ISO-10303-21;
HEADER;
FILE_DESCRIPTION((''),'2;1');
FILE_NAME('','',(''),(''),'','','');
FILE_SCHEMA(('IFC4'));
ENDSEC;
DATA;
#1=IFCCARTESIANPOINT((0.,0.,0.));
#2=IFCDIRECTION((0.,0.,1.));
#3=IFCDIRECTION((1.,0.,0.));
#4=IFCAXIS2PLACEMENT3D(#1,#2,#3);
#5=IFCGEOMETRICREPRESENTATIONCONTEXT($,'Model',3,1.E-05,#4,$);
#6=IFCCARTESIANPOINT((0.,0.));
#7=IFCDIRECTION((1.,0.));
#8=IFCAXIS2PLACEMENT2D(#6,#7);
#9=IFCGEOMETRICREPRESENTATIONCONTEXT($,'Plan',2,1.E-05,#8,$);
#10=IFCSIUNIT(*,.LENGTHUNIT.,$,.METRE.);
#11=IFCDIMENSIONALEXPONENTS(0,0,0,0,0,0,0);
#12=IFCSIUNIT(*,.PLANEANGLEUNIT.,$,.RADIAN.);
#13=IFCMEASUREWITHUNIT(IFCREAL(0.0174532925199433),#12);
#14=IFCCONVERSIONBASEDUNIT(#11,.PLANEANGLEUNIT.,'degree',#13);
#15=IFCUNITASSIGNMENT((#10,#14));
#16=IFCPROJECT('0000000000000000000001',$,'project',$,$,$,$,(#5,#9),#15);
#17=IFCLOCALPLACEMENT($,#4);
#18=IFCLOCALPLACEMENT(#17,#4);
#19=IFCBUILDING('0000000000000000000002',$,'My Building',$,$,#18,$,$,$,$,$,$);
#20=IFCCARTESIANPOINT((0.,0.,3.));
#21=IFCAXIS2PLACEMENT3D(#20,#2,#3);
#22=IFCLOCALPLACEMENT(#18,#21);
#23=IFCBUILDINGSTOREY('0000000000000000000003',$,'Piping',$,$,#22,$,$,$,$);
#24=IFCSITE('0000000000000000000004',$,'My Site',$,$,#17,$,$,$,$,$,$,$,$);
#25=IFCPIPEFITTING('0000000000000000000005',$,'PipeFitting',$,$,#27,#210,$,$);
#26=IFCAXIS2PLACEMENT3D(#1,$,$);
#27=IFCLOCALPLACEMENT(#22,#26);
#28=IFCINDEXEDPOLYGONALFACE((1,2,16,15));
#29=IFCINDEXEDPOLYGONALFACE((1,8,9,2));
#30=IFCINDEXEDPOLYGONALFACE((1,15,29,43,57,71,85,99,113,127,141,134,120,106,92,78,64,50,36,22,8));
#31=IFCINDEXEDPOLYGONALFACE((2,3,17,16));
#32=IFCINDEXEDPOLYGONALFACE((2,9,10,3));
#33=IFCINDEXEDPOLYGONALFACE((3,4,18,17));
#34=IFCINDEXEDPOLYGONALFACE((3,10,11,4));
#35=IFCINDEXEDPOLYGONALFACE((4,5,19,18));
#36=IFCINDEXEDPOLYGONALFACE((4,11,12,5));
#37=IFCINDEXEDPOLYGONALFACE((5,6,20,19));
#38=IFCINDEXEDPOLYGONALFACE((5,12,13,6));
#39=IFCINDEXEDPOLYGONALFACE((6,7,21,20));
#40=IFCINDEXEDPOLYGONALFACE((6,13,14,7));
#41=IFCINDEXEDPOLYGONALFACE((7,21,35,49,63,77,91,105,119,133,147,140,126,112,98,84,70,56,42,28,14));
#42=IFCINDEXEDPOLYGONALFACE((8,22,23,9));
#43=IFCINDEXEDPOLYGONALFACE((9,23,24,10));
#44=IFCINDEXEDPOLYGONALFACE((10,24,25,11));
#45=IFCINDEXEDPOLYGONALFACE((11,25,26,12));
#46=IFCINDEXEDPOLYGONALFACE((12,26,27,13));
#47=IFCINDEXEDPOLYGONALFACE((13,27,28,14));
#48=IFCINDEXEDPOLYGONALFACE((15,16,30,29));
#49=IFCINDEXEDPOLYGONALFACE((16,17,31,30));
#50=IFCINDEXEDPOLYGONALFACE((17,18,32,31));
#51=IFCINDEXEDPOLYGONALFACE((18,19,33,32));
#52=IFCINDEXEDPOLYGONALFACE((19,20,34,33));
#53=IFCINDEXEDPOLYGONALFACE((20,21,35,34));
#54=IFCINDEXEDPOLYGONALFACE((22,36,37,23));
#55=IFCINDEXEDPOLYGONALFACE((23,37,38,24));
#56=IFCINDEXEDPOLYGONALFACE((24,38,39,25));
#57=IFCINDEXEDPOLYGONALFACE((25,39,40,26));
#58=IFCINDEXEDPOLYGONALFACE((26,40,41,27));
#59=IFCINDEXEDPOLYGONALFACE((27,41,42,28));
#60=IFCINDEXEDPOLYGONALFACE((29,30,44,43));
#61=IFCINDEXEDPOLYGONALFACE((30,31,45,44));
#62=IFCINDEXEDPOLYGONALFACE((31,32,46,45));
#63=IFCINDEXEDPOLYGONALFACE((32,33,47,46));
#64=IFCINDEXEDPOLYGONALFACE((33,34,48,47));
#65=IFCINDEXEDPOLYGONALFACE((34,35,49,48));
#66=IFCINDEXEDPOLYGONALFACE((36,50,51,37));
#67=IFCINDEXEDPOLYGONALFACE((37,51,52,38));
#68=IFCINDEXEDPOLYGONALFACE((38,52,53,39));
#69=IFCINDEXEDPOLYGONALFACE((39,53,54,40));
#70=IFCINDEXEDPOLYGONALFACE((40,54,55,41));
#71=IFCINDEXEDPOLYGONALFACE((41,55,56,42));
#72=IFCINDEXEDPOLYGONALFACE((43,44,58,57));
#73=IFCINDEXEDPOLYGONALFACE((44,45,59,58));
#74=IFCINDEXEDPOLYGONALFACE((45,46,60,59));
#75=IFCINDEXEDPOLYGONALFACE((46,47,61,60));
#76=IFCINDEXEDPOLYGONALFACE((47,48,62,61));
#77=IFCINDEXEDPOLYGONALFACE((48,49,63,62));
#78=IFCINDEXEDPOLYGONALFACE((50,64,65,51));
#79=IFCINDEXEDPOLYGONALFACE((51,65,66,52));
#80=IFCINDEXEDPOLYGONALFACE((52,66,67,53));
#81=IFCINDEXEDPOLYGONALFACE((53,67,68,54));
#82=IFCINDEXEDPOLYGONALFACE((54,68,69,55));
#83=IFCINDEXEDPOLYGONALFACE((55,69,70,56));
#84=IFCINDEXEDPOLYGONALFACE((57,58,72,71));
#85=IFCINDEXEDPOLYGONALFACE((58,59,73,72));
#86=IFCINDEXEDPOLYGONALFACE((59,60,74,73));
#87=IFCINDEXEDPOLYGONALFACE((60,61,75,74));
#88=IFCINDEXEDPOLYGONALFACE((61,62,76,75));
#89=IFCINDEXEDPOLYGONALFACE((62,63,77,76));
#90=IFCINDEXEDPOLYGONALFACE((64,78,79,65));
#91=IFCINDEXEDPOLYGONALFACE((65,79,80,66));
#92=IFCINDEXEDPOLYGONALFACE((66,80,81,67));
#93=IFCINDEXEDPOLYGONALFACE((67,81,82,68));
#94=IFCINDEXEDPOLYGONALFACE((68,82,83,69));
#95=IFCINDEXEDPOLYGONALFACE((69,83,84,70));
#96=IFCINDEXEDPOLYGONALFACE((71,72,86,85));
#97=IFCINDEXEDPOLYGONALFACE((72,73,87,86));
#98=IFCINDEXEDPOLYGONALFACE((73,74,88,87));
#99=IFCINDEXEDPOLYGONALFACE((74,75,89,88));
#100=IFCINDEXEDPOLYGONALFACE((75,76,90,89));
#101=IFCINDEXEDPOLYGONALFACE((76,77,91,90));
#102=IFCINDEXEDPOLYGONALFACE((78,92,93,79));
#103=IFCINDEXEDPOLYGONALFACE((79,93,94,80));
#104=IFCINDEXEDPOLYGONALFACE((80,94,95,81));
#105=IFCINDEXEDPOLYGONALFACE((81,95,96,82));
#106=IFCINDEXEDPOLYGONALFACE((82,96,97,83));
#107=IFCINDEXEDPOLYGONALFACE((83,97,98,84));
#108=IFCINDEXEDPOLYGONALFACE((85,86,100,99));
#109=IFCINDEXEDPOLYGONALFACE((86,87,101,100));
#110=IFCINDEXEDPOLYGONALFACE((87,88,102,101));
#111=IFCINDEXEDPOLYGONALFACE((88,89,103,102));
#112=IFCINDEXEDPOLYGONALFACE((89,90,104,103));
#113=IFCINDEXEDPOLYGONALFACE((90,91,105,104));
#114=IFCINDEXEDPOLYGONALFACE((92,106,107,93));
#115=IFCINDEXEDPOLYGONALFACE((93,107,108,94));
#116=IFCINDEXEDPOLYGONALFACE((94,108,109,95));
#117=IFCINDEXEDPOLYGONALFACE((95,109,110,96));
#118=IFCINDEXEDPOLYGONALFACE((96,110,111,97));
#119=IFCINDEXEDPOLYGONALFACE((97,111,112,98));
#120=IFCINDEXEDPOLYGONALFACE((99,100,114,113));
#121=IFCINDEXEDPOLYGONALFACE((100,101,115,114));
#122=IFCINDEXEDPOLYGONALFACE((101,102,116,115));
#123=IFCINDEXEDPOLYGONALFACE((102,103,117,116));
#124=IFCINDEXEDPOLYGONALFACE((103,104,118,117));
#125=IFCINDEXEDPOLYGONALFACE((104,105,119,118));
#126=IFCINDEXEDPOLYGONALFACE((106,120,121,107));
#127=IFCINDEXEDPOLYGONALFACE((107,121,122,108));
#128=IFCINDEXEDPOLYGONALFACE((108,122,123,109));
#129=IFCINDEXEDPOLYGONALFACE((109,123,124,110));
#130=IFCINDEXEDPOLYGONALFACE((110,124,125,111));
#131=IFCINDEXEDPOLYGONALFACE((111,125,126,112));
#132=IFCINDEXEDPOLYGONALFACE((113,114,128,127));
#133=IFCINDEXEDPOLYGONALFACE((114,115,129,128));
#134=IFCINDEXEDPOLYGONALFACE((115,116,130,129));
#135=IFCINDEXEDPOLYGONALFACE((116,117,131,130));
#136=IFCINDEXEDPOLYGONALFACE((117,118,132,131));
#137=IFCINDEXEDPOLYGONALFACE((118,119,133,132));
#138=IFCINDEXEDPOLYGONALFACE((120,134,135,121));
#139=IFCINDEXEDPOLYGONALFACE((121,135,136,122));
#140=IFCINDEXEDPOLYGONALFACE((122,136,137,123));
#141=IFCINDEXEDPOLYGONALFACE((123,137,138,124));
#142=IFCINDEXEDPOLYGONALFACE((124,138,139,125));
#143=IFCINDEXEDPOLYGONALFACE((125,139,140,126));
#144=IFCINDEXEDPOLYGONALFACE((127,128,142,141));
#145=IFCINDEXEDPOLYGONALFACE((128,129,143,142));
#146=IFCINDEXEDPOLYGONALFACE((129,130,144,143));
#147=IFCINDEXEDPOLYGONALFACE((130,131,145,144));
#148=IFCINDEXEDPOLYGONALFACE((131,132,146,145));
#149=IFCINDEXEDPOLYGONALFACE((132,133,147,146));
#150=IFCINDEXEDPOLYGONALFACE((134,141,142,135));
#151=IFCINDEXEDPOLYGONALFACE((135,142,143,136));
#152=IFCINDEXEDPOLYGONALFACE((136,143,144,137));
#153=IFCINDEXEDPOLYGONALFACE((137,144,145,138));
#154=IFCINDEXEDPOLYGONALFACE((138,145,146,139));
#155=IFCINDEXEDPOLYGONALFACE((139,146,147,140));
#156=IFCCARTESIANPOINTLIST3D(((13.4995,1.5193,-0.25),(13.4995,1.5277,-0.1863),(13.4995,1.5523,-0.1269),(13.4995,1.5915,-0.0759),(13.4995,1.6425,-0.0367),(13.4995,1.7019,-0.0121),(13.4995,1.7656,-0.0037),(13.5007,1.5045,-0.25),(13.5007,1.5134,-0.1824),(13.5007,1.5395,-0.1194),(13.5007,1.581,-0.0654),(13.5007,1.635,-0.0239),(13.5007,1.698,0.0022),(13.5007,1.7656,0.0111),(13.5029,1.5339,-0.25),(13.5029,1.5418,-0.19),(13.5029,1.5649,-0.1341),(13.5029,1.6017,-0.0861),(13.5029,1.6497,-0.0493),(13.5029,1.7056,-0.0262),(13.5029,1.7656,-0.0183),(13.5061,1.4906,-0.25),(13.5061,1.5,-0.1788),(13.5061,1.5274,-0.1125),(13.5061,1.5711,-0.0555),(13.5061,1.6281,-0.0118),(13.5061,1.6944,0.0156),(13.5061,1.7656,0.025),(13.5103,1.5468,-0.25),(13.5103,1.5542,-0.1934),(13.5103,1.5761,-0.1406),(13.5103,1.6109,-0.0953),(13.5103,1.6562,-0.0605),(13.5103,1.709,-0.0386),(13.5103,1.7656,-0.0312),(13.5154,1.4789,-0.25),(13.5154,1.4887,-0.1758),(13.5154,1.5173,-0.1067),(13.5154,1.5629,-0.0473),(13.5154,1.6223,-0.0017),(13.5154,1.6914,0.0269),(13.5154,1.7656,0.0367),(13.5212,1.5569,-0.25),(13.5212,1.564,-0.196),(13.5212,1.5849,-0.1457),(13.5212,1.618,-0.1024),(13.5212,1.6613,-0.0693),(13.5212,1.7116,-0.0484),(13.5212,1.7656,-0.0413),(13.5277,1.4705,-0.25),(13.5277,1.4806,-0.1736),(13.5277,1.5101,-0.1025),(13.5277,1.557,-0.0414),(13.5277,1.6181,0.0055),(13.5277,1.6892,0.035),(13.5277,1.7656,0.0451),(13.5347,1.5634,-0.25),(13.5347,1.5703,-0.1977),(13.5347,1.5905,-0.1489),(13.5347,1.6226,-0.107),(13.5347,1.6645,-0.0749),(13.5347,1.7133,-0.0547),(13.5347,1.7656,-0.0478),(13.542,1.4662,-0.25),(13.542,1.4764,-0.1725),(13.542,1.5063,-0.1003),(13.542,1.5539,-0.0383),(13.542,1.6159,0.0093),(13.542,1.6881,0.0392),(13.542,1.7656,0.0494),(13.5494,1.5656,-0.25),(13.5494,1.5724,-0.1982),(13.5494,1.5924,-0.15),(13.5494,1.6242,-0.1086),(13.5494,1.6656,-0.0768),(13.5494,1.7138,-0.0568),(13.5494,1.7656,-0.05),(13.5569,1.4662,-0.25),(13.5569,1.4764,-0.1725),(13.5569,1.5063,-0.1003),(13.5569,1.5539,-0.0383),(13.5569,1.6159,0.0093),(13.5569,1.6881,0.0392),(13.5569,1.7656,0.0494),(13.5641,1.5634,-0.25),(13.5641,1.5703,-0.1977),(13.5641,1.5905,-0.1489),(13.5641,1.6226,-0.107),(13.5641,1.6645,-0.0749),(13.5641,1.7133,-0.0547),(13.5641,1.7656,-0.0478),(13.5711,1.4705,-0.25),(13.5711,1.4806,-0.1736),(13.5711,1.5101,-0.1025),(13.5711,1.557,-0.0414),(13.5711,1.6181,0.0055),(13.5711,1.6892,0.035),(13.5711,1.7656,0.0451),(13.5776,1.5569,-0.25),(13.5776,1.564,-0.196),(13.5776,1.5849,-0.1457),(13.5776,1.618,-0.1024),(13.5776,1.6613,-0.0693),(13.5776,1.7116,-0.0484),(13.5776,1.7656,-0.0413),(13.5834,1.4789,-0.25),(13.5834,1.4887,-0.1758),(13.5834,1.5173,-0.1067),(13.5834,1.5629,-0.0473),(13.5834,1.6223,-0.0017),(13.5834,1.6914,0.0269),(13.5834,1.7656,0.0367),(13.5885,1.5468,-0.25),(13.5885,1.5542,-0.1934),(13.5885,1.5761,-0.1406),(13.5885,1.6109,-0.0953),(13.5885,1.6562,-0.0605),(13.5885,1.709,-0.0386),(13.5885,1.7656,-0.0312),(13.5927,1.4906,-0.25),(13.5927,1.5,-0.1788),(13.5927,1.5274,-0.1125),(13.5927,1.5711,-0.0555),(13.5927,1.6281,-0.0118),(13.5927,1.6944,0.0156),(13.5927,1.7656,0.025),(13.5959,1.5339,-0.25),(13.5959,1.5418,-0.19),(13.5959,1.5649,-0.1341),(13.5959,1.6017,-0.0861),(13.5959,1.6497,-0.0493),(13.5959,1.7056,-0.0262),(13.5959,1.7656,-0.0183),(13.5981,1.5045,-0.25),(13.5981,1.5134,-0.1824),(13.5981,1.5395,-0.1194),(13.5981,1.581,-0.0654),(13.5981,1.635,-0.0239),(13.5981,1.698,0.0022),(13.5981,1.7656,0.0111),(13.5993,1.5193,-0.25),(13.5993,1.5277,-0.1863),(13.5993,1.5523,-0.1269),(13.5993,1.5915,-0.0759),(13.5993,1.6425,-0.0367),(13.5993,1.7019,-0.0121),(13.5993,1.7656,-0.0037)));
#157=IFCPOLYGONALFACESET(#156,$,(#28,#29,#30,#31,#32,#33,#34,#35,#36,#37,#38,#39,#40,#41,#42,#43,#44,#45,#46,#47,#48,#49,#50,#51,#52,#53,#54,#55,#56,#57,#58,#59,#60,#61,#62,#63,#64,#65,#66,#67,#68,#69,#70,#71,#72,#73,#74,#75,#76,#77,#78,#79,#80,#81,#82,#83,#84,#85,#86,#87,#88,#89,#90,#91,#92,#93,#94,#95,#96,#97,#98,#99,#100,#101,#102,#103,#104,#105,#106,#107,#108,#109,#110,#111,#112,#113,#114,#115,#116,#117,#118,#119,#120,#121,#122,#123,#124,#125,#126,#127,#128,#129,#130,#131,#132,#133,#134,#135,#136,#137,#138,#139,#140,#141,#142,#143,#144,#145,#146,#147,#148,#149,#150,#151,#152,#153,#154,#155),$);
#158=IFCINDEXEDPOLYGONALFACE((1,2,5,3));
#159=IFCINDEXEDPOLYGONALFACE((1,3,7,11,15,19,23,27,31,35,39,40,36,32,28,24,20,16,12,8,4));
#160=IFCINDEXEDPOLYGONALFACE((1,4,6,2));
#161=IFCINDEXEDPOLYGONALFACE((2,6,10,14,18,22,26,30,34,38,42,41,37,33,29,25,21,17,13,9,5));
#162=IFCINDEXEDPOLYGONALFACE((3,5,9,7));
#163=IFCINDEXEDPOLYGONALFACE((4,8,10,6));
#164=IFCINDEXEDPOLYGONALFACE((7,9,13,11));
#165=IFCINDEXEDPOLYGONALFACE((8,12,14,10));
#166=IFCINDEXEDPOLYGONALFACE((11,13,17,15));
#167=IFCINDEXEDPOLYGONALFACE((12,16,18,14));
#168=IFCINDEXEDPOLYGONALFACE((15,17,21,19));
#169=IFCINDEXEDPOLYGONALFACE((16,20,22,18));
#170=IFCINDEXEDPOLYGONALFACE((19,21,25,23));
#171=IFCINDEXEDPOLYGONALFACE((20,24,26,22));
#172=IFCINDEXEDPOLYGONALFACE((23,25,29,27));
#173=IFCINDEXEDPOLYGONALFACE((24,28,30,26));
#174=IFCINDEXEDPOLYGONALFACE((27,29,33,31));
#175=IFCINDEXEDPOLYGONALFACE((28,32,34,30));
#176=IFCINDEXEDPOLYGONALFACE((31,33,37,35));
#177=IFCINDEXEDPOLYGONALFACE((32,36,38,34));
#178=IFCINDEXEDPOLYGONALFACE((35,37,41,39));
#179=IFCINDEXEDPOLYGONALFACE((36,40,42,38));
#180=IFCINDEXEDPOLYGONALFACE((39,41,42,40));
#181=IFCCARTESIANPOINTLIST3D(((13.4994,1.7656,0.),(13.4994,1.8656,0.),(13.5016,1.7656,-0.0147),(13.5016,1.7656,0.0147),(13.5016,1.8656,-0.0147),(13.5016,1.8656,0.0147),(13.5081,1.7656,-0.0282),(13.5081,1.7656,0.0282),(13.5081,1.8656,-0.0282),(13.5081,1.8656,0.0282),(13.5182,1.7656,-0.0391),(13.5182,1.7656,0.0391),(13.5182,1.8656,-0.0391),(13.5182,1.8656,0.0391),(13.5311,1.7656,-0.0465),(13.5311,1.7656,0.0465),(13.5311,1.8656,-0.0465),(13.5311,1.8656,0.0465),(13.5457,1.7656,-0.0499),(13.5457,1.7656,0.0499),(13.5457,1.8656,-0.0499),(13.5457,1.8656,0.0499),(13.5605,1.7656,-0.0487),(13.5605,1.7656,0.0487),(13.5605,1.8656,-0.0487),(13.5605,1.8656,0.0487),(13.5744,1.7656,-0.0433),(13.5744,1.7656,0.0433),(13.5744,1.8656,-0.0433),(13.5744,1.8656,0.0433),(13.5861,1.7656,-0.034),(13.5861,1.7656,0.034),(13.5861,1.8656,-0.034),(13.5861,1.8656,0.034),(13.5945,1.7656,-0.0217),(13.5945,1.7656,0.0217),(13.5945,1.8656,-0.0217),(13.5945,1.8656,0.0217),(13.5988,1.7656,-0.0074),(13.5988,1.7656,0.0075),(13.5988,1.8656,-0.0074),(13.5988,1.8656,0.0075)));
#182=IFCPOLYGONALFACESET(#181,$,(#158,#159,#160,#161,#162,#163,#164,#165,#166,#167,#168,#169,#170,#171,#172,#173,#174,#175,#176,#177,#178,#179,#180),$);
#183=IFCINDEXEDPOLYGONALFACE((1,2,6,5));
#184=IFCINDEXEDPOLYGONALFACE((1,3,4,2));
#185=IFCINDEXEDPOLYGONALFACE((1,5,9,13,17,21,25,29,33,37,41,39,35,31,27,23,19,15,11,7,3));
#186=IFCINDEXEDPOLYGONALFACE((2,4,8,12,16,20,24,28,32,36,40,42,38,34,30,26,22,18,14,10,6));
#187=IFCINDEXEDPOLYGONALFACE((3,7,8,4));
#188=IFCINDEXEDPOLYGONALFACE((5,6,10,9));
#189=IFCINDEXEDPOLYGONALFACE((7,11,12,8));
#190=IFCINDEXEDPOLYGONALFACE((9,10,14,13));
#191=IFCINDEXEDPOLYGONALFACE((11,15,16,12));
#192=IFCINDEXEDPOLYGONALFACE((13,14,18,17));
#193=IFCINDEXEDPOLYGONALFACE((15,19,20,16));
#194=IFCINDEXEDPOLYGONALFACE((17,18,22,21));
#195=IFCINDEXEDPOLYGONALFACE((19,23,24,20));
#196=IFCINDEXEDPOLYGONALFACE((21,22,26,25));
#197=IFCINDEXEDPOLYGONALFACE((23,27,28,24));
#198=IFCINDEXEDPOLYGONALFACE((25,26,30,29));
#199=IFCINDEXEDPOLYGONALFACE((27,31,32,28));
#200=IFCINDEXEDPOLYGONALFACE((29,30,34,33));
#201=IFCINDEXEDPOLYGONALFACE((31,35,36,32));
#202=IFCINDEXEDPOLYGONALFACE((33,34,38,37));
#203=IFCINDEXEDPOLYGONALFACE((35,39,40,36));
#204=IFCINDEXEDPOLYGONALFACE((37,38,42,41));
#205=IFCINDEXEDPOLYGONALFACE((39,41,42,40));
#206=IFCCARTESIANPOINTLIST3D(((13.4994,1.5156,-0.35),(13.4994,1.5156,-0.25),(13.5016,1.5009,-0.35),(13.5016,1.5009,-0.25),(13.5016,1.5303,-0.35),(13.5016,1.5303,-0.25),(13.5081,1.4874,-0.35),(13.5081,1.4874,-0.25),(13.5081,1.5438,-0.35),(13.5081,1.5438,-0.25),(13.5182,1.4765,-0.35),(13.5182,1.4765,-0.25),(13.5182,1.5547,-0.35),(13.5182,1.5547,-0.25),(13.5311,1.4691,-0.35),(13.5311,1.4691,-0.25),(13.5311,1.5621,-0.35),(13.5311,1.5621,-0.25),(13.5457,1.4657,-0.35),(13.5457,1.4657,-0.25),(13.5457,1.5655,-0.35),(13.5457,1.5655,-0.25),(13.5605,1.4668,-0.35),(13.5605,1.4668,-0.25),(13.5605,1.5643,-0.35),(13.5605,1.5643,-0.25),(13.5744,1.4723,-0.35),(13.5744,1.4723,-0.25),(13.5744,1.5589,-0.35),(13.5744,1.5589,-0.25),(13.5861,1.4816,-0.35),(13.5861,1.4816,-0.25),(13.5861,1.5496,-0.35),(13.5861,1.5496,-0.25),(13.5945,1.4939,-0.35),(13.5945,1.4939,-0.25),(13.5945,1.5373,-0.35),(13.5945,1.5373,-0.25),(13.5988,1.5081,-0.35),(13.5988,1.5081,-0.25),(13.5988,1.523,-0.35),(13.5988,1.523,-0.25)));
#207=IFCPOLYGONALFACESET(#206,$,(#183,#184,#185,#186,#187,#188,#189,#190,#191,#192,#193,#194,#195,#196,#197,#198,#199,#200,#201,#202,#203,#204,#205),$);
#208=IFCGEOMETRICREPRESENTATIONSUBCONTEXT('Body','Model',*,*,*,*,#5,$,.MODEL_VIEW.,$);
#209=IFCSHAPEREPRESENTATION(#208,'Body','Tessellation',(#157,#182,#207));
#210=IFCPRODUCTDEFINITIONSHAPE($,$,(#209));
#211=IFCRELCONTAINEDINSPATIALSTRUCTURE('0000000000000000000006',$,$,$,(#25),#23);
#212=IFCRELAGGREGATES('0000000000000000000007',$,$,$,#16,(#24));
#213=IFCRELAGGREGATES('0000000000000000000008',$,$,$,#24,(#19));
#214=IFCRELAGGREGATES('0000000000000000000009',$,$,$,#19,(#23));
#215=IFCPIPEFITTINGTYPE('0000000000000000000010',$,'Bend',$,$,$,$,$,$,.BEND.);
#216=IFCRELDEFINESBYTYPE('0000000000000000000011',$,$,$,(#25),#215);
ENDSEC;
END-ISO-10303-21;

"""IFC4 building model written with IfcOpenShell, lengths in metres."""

from ifc_helpers import new_model, entity, si_unit, converted_unit, frame, origin_with_axes, origin_2d_with_axis, place, context, subcontext, project, spatial, circle, extrude, source, transform, mapped, type_object, type_shapes, element, save


model = new_model("IFC4")

# Units and contexts
model_context = context("Model", 3, precision=1e-05, world=origin_with_axes())
plan_context = context("Plan", 2, precision=1e-05, world=origin_2d_with_axis())
body_context = subcontext(model_context, "Body", "Model", "MODEL_VIEW")
ifc_project = project(units=[si_unit("LENGTHUNIT", "METRE"), converted_unit("PLANEANGLEUNIT", "degree", entity("IfcReal", 0.0174532925199433), si_unit("PLANEANGLEUNIT", "RADIAN"), dimensions=[0, 0, 0, 0, 0, 0, 0])], contexts=[model_context, plan_context])

# Site, building, storey
site_placement = place(None, origin_with_axes())
site = spatial("IfcSite", under=ifc_project, at=site_placement, Name="My Site")
building_placement = place(site_placement, origin_with_axes())
building = spatial("IfcBuilding", under=site, at=building_placement, Name="My Building")
storey_placement = place(building_placement, frame((0.0, 0.0, 3.0), z_axis=(0.0, 0.0, 1.0), x_axis=(1.0, 0.0, 0.0)))
storey = spatial("IfcBuildingStorey", under=building, at=storey_placement, Name="Piping")

# Shared definitions
pipe_fitting_type = type_object("IfcPipeFittingType", Name="Bend", PredefinedType="BEND")
shared_shape = source(origin_with_axes(), body_context, "Body", "SolidModel", [
    entity("IfcSweptDiskSolid", entity("IfcIndexedPolyCurve", entity("IfcCartesianPointList3D", [[0.0, 0.0, -0.1], [0.0, -0.0732, -0.2768], [0.0, -0.25, -0.35]]), [entity("IfcArcIndex", [1, 2, 3])]), 0.05),
    extrude(circle(Radius=0.05), origin_with_axes(), (0.0, 0.0, -1.0), 0.1),
    extrude(circle(Radius=0.05), frame((0.0, -0.25, -0.35), z_axis=(0.0, -1.0, 0.0), x_axis=(1.0, 0.0, 0.0)), (0.0, 0.0, 1.0), 0.1),
])
type_shapes(pipe_fitting_type, [shared_shape])

# Pipe fitting
for number, where, z_axis, x_axis, name in (
    (1, (13.5494, 1.8656, 0.0), (0.0, 1.0, 0.0), (-1.0, 0.0, 0.0), "PipeFitting"),
):
    element("IfcPipeFitting", number, at=place(storey_placement, frame(where, z_axis=z_axis, x_axis=x_axis)), inside=storey, type_object=pipe_fitting_type, Name=name, context=body_context, shape_type="MappedRepresentation", body=[
        mapped(shared_shape, transform((0.0, 0.0, 0.0), x_axis=(1.0, 0.0, 0.0), y_axis=(0.0, 1.0, 0.0), z_axis=(0.0, 0.0, 1.0), scale=1.0)),
    ])

save(model, "model.ifc")
